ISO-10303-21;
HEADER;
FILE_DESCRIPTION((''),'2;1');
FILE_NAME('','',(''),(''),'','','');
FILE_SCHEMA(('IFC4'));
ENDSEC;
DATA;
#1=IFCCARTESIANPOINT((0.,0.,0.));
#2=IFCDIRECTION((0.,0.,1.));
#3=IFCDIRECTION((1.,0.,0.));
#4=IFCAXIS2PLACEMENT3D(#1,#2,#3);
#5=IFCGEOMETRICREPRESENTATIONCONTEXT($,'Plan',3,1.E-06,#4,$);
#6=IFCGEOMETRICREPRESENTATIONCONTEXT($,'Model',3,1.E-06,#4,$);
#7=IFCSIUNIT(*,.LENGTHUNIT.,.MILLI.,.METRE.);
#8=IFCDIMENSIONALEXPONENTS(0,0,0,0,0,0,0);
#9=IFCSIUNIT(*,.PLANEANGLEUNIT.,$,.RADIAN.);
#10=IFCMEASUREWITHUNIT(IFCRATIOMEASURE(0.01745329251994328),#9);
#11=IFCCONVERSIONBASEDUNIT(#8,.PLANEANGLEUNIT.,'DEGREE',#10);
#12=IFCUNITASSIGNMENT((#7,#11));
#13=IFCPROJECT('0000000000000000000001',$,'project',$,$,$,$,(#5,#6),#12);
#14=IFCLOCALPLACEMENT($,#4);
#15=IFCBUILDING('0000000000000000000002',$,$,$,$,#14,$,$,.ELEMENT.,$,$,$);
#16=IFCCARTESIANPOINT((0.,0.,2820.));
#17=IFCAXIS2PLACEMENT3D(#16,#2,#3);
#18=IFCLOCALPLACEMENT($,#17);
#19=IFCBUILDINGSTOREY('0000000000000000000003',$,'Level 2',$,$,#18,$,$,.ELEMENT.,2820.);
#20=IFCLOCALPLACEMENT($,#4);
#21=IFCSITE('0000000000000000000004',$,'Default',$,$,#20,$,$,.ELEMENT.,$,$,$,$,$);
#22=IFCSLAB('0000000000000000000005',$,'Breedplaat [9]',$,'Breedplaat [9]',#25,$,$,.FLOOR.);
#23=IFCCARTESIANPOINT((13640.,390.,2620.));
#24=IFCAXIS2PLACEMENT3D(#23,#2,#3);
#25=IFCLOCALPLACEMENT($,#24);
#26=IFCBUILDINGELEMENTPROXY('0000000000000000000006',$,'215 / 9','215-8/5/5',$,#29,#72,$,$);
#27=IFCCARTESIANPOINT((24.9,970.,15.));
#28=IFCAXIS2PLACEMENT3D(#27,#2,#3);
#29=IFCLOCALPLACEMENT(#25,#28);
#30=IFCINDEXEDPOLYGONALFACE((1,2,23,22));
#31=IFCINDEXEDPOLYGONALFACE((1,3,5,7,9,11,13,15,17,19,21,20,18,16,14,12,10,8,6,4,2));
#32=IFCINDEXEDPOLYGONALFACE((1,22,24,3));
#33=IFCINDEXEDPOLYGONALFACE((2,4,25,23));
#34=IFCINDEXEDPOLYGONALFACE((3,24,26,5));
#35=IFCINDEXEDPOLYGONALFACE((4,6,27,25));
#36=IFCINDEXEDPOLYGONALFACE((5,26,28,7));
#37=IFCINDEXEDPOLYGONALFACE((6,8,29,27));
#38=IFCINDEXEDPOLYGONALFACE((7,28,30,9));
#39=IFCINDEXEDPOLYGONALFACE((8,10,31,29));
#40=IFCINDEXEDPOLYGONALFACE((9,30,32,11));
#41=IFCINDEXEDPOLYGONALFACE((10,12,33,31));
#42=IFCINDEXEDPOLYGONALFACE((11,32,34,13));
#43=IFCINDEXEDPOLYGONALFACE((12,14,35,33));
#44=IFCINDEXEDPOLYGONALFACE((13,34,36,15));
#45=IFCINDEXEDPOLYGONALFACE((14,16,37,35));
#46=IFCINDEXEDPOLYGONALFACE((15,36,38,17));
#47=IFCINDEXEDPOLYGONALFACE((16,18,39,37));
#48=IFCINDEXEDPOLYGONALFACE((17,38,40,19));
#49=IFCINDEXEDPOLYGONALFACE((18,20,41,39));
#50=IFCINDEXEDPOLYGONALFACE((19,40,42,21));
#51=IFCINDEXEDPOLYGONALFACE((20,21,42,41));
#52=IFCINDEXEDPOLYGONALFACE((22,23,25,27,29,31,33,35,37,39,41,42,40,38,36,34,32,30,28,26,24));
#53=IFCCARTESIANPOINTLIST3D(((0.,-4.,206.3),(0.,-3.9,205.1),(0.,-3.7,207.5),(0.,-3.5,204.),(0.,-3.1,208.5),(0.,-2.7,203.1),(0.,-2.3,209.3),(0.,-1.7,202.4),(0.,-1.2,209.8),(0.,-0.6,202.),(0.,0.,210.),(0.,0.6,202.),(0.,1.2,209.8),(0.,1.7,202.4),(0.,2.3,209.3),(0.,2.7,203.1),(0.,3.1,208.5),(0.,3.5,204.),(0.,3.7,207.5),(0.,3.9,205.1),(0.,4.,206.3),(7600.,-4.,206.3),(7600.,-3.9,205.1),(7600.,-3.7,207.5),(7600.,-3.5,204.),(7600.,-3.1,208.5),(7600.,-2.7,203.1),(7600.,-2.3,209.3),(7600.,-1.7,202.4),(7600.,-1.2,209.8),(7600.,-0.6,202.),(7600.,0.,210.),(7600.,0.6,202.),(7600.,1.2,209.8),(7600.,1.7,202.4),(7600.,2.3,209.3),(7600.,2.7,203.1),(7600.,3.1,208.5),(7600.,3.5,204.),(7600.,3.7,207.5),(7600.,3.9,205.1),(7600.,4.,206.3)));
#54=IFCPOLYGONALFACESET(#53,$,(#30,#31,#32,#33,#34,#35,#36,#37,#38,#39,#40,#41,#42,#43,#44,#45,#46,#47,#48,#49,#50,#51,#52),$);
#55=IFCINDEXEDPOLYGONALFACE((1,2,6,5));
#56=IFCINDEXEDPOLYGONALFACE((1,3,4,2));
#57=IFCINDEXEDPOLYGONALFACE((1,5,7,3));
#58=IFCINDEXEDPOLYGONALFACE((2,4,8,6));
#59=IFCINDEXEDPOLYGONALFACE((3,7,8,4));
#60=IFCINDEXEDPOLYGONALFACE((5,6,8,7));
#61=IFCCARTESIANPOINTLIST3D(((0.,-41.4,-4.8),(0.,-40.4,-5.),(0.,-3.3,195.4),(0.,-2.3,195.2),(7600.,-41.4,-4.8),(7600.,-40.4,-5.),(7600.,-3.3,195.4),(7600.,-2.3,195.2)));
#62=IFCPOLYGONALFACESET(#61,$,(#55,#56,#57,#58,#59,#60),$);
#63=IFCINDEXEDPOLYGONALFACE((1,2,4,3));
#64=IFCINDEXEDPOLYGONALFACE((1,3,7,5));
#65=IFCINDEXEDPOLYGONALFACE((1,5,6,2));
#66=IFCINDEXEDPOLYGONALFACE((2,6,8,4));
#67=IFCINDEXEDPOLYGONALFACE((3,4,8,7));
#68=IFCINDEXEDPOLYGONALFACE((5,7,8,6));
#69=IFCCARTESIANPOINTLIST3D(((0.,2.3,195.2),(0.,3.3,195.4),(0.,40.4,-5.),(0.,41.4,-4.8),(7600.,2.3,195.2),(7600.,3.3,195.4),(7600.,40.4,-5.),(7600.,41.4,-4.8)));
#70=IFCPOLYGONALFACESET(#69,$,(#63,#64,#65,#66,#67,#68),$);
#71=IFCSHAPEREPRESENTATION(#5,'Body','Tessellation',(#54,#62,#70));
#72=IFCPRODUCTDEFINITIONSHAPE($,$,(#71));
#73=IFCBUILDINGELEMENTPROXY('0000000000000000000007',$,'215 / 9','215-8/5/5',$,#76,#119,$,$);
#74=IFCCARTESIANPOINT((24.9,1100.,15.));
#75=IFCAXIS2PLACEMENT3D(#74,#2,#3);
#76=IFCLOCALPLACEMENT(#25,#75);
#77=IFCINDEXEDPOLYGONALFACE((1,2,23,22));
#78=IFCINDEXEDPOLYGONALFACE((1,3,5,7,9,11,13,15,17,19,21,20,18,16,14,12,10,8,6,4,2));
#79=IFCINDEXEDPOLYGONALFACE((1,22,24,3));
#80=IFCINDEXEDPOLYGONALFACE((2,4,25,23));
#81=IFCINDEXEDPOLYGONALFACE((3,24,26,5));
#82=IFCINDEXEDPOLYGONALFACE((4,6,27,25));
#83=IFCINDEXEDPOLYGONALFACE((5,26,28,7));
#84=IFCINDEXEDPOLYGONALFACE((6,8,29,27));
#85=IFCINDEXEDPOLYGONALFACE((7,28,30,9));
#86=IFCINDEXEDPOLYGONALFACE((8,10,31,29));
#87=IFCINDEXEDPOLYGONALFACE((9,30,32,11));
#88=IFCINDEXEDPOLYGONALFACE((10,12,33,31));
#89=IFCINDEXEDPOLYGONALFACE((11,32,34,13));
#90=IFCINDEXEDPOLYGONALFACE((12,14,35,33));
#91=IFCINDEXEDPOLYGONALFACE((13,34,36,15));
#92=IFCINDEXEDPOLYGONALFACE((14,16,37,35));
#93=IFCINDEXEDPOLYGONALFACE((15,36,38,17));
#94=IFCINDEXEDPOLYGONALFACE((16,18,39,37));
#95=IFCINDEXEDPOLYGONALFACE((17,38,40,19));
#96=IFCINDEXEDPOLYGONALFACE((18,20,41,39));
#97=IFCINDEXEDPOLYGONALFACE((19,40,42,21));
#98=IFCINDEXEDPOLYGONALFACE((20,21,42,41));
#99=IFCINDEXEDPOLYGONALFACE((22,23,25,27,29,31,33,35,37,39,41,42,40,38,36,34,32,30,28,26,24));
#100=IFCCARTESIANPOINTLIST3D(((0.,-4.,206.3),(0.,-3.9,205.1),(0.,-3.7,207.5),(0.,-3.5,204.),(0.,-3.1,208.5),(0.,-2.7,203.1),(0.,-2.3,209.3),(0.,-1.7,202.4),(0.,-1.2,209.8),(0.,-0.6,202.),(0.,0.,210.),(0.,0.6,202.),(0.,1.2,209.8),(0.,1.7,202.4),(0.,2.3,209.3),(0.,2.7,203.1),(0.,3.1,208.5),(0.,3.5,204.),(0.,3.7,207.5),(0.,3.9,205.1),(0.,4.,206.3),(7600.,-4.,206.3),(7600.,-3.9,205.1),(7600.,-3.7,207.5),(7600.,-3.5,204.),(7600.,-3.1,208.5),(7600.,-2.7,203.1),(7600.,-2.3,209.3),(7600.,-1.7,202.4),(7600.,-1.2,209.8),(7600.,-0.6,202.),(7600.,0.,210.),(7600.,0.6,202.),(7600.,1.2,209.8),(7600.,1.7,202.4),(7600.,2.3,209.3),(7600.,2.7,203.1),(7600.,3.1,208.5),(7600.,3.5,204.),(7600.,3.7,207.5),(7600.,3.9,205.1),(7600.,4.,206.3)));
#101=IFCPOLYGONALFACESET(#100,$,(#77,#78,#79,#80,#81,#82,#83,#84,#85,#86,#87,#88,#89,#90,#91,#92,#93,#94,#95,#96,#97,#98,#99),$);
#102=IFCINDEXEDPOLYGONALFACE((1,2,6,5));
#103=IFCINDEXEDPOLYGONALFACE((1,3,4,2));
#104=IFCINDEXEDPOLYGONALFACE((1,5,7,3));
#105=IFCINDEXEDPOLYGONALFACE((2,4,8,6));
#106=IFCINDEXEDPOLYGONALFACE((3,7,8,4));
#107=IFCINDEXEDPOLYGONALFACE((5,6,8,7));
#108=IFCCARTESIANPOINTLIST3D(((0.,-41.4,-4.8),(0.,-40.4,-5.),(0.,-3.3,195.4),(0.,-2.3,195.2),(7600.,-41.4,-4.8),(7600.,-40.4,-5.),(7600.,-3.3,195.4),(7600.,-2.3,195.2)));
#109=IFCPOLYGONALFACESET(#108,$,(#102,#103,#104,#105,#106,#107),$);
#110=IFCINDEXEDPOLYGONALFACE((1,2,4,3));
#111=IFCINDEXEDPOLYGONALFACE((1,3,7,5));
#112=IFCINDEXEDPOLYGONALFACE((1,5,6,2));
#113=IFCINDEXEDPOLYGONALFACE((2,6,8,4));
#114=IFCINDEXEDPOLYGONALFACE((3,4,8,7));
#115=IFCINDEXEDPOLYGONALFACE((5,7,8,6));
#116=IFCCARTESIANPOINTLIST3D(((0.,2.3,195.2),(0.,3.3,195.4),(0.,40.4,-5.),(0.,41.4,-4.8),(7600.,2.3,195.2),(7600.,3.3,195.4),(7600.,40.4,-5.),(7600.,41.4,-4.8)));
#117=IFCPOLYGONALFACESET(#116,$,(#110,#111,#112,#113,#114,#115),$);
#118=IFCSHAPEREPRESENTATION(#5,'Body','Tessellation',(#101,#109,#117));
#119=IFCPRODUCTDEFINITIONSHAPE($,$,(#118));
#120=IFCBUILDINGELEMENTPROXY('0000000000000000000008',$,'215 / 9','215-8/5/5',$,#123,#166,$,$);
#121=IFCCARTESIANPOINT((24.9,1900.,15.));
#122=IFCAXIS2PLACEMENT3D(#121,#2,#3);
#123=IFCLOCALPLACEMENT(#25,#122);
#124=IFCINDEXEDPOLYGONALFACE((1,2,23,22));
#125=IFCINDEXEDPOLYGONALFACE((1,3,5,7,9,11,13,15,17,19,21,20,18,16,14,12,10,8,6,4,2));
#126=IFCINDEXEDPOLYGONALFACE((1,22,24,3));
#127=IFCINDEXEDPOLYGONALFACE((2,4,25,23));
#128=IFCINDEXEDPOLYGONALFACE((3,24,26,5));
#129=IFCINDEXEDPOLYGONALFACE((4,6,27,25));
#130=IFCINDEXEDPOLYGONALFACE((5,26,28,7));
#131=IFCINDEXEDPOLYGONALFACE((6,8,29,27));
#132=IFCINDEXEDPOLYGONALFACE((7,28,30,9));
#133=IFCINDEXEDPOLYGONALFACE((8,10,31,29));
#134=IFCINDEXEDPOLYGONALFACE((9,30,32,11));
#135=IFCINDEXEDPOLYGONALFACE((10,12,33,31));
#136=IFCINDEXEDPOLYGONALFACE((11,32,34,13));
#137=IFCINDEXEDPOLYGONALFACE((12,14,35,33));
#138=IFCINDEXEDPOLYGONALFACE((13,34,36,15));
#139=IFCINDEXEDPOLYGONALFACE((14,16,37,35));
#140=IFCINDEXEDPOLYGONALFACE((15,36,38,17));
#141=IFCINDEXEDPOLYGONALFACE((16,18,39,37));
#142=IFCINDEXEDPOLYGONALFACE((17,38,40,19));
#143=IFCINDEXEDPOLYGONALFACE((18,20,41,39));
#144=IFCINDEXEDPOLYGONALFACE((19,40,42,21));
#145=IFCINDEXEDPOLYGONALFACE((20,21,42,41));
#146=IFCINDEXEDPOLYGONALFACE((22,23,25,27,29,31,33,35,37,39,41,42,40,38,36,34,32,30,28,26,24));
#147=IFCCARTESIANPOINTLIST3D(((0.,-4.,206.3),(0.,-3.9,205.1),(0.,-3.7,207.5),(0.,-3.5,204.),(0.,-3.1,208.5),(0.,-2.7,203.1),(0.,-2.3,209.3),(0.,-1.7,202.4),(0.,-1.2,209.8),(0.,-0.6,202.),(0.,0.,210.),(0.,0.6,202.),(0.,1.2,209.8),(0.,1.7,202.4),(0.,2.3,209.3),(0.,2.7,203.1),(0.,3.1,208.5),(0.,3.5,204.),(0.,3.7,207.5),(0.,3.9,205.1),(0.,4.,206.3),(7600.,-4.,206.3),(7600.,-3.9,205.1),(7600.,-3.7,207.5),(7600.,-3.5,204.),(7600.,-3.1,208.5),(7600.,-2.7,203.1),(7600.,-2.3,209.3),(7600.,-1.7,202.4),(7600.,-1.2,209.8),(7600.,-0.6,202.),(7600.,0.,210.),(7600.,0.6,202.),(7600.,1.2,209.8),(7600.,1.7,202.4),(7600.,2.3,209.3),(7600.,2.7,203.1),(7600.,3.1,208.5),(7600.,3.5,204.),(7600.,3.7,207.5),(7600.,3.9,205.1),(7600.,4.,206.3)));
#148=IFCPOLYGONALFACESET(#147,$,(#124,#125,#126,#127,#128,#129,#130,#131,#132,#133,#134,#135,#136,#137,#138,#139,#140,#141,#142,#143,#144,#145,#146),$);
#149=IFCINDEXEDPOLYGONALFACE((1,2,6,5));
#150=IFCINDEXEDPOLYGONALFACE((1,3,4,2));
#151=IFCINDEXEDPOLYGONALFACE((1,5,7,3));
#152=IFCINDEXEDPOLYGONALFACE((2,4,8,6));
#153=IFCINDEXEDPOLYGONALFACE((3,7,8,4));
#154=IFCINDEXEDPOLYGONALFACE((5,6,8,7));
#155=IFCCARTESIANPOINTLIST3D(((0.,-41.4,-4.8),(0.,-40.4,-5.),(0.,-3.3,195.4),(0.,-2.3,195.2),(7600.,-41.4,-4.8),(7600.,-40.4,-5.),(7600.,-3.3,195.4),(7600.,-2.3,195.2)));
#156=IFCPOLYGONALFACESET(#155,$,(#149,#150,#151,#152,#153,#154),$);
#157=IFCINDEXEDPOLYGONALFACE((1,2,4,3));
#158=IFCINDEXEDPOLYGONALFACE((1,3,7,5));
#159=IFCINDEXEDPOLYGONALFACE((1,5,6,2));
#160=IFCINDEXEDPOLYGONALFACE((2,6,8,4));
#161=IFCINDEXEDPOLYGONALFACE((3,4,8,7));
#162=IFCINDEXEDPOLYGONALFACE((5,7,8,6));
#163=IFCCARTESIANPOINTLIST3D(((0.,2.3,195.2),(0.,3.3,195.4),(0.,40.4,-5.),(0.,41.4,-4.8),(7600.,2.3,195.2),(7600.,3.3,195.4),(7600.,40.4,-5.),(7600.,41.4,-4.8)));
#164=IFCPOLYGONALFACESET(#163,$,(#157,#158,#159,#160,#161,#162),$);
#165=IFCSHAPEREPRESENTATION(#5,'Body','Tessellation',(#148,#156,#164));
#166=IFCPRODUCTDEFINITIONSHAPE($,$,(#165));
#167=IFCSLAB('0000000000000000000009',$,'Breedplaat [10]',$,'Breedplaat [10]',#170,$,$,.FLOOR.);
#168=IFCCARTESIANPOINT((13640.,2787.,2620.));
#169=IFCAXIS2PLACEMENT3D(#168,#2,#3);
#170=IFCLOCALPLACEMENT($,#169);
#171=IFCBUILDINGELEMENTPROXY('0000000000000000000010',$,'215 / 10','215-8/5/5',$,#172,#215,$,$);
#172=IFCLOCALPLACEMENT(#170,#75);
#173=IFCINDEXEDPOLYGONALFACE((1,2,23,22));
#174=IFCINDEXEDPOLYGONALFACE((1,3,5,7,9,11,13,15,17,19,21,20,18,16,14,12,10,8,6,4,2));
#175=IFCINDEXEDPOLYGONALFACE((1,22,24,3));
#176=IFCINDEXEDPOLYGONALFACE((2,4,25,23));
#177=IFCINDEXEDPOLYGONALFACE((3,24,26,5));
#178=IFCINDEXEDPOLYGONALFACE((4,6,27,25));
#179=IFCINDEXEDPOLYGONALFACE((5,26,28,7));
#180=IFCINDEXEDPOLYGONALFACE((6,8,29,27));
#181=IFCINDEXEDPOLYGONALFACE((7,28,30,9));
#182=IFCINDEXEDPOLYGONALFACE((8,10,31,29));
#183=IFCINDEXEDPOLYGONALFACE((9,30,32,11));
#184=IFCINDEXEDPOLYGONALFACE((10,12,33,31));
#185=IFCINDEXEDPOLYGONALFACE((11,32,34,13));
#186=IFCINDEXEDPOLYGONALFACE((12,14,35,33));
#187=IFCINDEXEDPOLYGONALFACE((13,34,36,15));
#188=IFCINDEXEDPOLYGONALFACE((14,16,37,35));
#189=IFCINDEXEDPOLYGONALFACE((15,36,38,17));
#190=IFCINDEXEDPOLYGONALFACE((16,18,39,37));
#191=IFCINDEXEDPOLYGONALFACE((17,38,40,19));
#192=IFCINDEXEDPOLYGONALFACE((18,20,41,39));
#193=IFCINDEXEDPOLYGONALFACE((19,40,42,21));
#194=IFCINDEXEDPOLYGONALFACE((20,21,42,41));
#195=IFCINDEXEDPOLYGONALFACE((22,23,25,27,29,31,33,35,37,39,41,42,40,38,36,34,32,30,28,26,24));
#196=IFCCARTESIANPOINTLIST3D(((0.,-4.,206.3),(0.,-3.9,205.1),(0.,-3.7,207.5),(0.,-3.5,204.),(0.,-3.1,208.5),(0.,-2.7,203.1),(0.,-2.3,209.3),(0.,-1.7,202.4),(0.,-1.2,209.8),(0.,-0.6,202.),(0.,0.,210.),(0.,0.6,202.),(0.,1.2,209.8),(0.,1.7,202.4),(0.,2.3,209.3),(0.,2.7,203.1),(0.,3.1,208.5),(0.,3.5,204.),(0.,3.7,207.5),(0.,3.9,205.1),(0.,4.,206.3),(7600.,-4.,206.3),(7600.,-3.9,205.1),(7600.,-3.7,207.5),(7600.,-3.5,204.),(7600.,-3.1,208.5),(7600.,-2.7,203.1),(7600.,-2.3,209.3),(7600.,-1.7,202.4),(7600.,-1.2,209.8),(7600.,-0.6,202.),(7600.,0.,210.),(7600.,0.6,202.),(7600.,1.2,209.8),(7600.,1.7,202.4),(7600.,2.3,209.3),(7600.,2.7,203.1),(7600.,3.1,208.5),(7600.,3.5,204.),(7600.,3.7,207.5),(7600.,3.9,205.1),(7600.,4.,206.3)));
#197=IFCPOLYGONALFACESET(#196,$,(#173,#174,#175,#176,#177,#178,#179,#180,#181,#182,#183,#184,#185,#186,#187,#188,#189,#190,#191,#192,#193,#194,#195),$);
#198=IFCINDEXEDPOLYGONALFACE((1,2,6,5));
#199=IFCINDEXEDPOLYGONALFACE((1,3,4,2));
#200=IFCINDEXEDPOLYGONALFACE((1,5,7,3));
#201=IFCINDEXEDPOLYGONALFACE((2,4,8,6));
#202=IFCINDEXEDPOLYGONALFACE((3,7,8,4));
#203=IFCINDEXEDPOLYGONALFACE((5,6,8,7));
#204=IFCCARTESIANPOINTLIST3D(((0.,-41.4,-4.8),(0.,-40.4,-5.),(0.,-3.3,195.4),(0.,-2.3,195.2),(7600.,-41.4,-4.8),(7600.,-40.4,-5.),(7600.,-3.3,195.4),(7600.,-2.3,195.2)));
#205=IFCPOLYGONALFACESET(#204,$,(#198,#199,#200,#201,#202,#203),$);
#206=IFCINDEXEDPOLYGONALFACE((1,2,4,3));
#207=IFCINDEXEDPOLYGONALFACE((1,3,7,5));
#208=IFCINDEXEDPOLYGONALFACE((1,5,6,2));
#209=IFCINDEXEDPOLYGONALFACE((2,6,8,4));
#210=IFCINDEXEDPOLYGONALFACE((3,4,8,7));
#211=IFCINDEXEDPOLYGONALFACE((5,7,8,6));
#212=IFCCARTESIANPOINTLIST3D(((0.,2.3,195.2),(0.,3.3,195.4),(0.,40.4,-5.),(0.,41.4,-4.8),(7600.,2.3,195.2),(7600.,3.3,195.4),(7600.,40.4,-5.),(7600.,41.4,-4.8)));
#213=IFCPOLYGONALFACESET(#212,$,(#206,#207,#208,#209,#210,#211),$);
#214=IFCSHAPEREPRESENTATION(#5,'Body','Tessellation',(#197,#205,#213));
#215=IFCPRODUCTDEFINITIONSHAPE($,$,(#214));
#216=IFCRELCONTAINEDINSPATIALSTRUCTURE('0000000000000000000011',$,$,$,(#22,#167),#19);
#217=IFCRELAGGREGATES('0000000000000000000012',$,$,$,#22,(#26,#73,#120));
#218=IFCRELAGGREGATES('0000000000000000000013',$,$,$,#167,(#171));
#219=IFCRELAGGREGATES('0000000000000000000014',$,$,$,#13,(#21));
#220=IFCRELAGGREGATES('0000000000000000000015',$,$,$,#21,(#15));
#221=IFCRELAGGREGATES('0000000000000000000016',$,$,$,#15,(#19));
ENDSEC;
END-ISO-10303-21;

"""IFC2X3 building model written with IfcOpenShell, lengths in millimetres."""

from ifc_helpers import new_model, entity, si_unit, converted_unit, frame, origin_with_axes, origin_2d_with_axis, place, context, project, spatial, rectangle, circle, extrude, element, aggregate, save


model = new_model("IFC2X3")

# Units and contexts
plan_context = context("Plan", 3, precision=1e-06, world=origin_with_axes())
model_context = context("Model", 3, precision=1e-06, world=origin_with_axes())
ifc_project = project(units=[si_unit("LENGTHUNIT", "METRE", prefix="MILLI"), converted_unit("PLANEANGLEUNIT", "DEGREE", entity("IfcRatioMeasure", 0.01745329251994328), si_unit("PLANEANGLEUNIT", "RADIAN"), dimensions=[0, 0, 0, 0, 0, 0, 0])], contexts=[plan_context, model_context])

# Site, building, storey
site_placement = place(None, origin_with_axes())
site = spatial("IfcSite", under=ifc_project, at=site_placement, Name="Default", CompositionType="ELEMENT")
building_placement = place(None, origin_with_axes())
building = spatial("IfcBuilding", under=site, at=building_placement, CompositionType="ELEMENT")
storey_placement = place(None, frame((0.0, 0.0, 2820.0), z_axis=(0.0, 0.0, 1.0), x_axis=(1.0, 0.0, 0.0)))
storey = spatial("IfcBuildingStorey", under=building, at=storey_placement, Name="Level 2", CompositionType="ELEMENT", Elevation=2820.0)

# Slabs, building element proxies
slab_1_placement = place(None, frame((13640.0, 390.0, 2620.0), z_axis=(0.0, 0.0, 1.0), x_axis=(1.0, 0.0, 0.0)))
slab_1 = element("IfcSlab", 1, at=slab_1_placement, inside=storey, Name="Breedplaat [9]", ObjectType="Breedplaat [9]", PredefinedType="FLOOR")
proxy_1_placement = place(slab_1_placement, frame((24.9, 970.0, 15.0), z_axis=(0.0, 0.0, 1.0), x_axis=(1.0, 0.0, 0.0)))
proxy_1 = element("IfcBuildingElementProxy", 2, at=proxy_1_placement, Name="215 / 9", Description="215-8/5/5", context=plan_context, shape_type="SweptSolid", body=[
    extrude(circle(Radius=4.0, at=origin_2d_with_axis()), frame((0.0, 0.0, 206.0), z_axis=(1.0, 0.0, 0.0), x_axis=(0.0, 0.0, 1.0)), (0.0, 0.0, 1.0), 7600.0),
    extrude(rectangle(XDim=203.8, YDim=1.0, at=origin_2d_with_axis()), frame((0.0, -21.9, 95.2), z_axis=(1.0, 0.0, 0.0), x_axis=(0.0, 0.187112, 0.982339)), (0.0, 0.0, 1.0), 7600.0),
    extrude(rectangle(XDim=203.8, YDim=1.0, at=origin_2d_with_axis()), frame((0.0, 21.9, 95.2), z_axis=(1.0, 0.0, 0.0), x_axis=(0.0, -0.187112, 0.982339)), (0.0, 0.0, 1.0), 7600.0),
])
proxy_2_placement = place(slab_1_placement, frame((24.9, 1100.0, 15.0), z_axis=(0.0, 0.0, 1.0), x_axis=(1.0, 0.0, 0.0)))
proxy_2 = element("IfcBuildingElementProxy", 3, at=proxy_2_placement, Name="215 / 9", Description="215-8/5/5", context=plan_context, shape_type="SweptSolid", body=[
    extrude(circle(Radius=4.0, at=origin_2d_with_axis()), frame((0.0, 0.0, 206.0), z_axis=(1.0, 0.0, 0.0), x_axis=(0.0, 0.0, 1.0)), (0.0, 0.0, 1.0), 7600.0),
    extrude(rectangle(XDim=203.8, YDim=1.0, at=origin_2d_with_axis()), frame((0.0, -21.9, 95.2), z_axis=(1.0, 0.0, 0.0), x_axis=(0.0, 0.187112, 0.982339)), (0.0, 0.0, 1.0), 7600.0),
    extrude(rectangle(XDim=203.8, YDim=1.0, at=origin_2d_with_axis()), frame((0.0, 21.9, 95.2), z_axis=(1.0, 0.0, 0.0), x_axis=(0.0, -0.187112, 0.982339)), (0.0, 0.0, 1.0), 7600.0),
])
proxy_3_placement = place(slab_1_placement, frame((24.9, 1900.0, 15.0), z_axis=(0.0, 0.0, 1.0), x_axis=(1.0, 0.0, 0.0)))
proxy_3 = element("IfcBuildingElementProxy", 4, at=proxy_3_placement, Name="215 / 9", Description="215-8/5/5", context=plan_context, shape_type="SweptSolid", body=[
    extrude(circle(Radius=4.0, at=origin_2d_with_axis()), frame((0.0, 0.0, 206.0), z_axis=(1.0, 0.0, 0.0), x_axis=(0.0, 0.0, 1.0)), (0.0, 0.0, 1.0), 7600.0),
    extrude(rectangle(XDim=203.8, YDim=1.0, at=origin_2d_with_axis()), frame((0.0, -21.9, 95.2), z_axis=(1.0, 0.0, 0.0), x_axis=(0.0, 0.187112, 0.982339)), (0.0, 0.0, 1.0), 7600.0),
    extrude(rectangle(XDim=203.8, YDim=1.0, at=origin_2d_with_axis()), frame((0.0, 21.9, 95.2), z_axis=(1.0, 0.0, 0.0), x_axis=(0.0, -0.187112, 0.982339)), (0.0, 0.0, 1.0), 7600.0),
])
aggregate(slab_1, [proxy_1, proxy_2, proxy_3])
slab_2_placement = place(None, frame((13640.0, 2787.0, 2620.0), z_axis=(0.0, 0.0, 1.0), x_axis=(1.0, 0.0, 0.0)))
slab_2 = element("IfcSlab", 5, at=slab_2_placement, inside=storey, Name="Breedplaat [10]", ObjectType="Breedplaat [10]", PredefinedType="FLOOR")
proxy_4_placement = place(slab_2_placement, frame((24.9, 1100.0, 15.0), z_axis=(0.0, 0.0, 1.0), x_axis=(1.0, 0.0, 0.0)))
proxy_4 = element("IfcBuildingElementProxy", 6, at=proxy_4_placement, Name="215 / 10", Description="215-8/5/5", context=plan_context, shape_type="SweptSolid", body=[
    extrude(circle(Radius=4.0, at=origin_2d_with_axis()), frame((0.0, 0.0, 206.0), z_axis=(1.0, 0.0, 0.0), x_axis=(0.0, 0.0, 1.0)), (0.0, 0.0, 1.0), 7600.0),
    extrude(rectangle(XDim=203.8, YDim=1.0, at=origin_2d_with_axis()), frame((0.0, -21.9, 95.2), z_axis=(1.0, 0.0, 0.0), x_axis=(0.0, 0.187112, 0.982339)), (0.0, 0.0, 1.0), 7600.0),
    extrude(rectangle(XDim=203.8, YDim=1.0, at=origin_2d_with_axis()), frame((0.0, 21.9, 95.2), z_axis=(1.0, 0.0, 0.0), x_axis=(0.0, -0.187112, 0.982339)), (0.0, 0.0, 1.0), 7600.0),
])
aggregate(slab_2, [proxy_4])

save(model, "model.ifc")
